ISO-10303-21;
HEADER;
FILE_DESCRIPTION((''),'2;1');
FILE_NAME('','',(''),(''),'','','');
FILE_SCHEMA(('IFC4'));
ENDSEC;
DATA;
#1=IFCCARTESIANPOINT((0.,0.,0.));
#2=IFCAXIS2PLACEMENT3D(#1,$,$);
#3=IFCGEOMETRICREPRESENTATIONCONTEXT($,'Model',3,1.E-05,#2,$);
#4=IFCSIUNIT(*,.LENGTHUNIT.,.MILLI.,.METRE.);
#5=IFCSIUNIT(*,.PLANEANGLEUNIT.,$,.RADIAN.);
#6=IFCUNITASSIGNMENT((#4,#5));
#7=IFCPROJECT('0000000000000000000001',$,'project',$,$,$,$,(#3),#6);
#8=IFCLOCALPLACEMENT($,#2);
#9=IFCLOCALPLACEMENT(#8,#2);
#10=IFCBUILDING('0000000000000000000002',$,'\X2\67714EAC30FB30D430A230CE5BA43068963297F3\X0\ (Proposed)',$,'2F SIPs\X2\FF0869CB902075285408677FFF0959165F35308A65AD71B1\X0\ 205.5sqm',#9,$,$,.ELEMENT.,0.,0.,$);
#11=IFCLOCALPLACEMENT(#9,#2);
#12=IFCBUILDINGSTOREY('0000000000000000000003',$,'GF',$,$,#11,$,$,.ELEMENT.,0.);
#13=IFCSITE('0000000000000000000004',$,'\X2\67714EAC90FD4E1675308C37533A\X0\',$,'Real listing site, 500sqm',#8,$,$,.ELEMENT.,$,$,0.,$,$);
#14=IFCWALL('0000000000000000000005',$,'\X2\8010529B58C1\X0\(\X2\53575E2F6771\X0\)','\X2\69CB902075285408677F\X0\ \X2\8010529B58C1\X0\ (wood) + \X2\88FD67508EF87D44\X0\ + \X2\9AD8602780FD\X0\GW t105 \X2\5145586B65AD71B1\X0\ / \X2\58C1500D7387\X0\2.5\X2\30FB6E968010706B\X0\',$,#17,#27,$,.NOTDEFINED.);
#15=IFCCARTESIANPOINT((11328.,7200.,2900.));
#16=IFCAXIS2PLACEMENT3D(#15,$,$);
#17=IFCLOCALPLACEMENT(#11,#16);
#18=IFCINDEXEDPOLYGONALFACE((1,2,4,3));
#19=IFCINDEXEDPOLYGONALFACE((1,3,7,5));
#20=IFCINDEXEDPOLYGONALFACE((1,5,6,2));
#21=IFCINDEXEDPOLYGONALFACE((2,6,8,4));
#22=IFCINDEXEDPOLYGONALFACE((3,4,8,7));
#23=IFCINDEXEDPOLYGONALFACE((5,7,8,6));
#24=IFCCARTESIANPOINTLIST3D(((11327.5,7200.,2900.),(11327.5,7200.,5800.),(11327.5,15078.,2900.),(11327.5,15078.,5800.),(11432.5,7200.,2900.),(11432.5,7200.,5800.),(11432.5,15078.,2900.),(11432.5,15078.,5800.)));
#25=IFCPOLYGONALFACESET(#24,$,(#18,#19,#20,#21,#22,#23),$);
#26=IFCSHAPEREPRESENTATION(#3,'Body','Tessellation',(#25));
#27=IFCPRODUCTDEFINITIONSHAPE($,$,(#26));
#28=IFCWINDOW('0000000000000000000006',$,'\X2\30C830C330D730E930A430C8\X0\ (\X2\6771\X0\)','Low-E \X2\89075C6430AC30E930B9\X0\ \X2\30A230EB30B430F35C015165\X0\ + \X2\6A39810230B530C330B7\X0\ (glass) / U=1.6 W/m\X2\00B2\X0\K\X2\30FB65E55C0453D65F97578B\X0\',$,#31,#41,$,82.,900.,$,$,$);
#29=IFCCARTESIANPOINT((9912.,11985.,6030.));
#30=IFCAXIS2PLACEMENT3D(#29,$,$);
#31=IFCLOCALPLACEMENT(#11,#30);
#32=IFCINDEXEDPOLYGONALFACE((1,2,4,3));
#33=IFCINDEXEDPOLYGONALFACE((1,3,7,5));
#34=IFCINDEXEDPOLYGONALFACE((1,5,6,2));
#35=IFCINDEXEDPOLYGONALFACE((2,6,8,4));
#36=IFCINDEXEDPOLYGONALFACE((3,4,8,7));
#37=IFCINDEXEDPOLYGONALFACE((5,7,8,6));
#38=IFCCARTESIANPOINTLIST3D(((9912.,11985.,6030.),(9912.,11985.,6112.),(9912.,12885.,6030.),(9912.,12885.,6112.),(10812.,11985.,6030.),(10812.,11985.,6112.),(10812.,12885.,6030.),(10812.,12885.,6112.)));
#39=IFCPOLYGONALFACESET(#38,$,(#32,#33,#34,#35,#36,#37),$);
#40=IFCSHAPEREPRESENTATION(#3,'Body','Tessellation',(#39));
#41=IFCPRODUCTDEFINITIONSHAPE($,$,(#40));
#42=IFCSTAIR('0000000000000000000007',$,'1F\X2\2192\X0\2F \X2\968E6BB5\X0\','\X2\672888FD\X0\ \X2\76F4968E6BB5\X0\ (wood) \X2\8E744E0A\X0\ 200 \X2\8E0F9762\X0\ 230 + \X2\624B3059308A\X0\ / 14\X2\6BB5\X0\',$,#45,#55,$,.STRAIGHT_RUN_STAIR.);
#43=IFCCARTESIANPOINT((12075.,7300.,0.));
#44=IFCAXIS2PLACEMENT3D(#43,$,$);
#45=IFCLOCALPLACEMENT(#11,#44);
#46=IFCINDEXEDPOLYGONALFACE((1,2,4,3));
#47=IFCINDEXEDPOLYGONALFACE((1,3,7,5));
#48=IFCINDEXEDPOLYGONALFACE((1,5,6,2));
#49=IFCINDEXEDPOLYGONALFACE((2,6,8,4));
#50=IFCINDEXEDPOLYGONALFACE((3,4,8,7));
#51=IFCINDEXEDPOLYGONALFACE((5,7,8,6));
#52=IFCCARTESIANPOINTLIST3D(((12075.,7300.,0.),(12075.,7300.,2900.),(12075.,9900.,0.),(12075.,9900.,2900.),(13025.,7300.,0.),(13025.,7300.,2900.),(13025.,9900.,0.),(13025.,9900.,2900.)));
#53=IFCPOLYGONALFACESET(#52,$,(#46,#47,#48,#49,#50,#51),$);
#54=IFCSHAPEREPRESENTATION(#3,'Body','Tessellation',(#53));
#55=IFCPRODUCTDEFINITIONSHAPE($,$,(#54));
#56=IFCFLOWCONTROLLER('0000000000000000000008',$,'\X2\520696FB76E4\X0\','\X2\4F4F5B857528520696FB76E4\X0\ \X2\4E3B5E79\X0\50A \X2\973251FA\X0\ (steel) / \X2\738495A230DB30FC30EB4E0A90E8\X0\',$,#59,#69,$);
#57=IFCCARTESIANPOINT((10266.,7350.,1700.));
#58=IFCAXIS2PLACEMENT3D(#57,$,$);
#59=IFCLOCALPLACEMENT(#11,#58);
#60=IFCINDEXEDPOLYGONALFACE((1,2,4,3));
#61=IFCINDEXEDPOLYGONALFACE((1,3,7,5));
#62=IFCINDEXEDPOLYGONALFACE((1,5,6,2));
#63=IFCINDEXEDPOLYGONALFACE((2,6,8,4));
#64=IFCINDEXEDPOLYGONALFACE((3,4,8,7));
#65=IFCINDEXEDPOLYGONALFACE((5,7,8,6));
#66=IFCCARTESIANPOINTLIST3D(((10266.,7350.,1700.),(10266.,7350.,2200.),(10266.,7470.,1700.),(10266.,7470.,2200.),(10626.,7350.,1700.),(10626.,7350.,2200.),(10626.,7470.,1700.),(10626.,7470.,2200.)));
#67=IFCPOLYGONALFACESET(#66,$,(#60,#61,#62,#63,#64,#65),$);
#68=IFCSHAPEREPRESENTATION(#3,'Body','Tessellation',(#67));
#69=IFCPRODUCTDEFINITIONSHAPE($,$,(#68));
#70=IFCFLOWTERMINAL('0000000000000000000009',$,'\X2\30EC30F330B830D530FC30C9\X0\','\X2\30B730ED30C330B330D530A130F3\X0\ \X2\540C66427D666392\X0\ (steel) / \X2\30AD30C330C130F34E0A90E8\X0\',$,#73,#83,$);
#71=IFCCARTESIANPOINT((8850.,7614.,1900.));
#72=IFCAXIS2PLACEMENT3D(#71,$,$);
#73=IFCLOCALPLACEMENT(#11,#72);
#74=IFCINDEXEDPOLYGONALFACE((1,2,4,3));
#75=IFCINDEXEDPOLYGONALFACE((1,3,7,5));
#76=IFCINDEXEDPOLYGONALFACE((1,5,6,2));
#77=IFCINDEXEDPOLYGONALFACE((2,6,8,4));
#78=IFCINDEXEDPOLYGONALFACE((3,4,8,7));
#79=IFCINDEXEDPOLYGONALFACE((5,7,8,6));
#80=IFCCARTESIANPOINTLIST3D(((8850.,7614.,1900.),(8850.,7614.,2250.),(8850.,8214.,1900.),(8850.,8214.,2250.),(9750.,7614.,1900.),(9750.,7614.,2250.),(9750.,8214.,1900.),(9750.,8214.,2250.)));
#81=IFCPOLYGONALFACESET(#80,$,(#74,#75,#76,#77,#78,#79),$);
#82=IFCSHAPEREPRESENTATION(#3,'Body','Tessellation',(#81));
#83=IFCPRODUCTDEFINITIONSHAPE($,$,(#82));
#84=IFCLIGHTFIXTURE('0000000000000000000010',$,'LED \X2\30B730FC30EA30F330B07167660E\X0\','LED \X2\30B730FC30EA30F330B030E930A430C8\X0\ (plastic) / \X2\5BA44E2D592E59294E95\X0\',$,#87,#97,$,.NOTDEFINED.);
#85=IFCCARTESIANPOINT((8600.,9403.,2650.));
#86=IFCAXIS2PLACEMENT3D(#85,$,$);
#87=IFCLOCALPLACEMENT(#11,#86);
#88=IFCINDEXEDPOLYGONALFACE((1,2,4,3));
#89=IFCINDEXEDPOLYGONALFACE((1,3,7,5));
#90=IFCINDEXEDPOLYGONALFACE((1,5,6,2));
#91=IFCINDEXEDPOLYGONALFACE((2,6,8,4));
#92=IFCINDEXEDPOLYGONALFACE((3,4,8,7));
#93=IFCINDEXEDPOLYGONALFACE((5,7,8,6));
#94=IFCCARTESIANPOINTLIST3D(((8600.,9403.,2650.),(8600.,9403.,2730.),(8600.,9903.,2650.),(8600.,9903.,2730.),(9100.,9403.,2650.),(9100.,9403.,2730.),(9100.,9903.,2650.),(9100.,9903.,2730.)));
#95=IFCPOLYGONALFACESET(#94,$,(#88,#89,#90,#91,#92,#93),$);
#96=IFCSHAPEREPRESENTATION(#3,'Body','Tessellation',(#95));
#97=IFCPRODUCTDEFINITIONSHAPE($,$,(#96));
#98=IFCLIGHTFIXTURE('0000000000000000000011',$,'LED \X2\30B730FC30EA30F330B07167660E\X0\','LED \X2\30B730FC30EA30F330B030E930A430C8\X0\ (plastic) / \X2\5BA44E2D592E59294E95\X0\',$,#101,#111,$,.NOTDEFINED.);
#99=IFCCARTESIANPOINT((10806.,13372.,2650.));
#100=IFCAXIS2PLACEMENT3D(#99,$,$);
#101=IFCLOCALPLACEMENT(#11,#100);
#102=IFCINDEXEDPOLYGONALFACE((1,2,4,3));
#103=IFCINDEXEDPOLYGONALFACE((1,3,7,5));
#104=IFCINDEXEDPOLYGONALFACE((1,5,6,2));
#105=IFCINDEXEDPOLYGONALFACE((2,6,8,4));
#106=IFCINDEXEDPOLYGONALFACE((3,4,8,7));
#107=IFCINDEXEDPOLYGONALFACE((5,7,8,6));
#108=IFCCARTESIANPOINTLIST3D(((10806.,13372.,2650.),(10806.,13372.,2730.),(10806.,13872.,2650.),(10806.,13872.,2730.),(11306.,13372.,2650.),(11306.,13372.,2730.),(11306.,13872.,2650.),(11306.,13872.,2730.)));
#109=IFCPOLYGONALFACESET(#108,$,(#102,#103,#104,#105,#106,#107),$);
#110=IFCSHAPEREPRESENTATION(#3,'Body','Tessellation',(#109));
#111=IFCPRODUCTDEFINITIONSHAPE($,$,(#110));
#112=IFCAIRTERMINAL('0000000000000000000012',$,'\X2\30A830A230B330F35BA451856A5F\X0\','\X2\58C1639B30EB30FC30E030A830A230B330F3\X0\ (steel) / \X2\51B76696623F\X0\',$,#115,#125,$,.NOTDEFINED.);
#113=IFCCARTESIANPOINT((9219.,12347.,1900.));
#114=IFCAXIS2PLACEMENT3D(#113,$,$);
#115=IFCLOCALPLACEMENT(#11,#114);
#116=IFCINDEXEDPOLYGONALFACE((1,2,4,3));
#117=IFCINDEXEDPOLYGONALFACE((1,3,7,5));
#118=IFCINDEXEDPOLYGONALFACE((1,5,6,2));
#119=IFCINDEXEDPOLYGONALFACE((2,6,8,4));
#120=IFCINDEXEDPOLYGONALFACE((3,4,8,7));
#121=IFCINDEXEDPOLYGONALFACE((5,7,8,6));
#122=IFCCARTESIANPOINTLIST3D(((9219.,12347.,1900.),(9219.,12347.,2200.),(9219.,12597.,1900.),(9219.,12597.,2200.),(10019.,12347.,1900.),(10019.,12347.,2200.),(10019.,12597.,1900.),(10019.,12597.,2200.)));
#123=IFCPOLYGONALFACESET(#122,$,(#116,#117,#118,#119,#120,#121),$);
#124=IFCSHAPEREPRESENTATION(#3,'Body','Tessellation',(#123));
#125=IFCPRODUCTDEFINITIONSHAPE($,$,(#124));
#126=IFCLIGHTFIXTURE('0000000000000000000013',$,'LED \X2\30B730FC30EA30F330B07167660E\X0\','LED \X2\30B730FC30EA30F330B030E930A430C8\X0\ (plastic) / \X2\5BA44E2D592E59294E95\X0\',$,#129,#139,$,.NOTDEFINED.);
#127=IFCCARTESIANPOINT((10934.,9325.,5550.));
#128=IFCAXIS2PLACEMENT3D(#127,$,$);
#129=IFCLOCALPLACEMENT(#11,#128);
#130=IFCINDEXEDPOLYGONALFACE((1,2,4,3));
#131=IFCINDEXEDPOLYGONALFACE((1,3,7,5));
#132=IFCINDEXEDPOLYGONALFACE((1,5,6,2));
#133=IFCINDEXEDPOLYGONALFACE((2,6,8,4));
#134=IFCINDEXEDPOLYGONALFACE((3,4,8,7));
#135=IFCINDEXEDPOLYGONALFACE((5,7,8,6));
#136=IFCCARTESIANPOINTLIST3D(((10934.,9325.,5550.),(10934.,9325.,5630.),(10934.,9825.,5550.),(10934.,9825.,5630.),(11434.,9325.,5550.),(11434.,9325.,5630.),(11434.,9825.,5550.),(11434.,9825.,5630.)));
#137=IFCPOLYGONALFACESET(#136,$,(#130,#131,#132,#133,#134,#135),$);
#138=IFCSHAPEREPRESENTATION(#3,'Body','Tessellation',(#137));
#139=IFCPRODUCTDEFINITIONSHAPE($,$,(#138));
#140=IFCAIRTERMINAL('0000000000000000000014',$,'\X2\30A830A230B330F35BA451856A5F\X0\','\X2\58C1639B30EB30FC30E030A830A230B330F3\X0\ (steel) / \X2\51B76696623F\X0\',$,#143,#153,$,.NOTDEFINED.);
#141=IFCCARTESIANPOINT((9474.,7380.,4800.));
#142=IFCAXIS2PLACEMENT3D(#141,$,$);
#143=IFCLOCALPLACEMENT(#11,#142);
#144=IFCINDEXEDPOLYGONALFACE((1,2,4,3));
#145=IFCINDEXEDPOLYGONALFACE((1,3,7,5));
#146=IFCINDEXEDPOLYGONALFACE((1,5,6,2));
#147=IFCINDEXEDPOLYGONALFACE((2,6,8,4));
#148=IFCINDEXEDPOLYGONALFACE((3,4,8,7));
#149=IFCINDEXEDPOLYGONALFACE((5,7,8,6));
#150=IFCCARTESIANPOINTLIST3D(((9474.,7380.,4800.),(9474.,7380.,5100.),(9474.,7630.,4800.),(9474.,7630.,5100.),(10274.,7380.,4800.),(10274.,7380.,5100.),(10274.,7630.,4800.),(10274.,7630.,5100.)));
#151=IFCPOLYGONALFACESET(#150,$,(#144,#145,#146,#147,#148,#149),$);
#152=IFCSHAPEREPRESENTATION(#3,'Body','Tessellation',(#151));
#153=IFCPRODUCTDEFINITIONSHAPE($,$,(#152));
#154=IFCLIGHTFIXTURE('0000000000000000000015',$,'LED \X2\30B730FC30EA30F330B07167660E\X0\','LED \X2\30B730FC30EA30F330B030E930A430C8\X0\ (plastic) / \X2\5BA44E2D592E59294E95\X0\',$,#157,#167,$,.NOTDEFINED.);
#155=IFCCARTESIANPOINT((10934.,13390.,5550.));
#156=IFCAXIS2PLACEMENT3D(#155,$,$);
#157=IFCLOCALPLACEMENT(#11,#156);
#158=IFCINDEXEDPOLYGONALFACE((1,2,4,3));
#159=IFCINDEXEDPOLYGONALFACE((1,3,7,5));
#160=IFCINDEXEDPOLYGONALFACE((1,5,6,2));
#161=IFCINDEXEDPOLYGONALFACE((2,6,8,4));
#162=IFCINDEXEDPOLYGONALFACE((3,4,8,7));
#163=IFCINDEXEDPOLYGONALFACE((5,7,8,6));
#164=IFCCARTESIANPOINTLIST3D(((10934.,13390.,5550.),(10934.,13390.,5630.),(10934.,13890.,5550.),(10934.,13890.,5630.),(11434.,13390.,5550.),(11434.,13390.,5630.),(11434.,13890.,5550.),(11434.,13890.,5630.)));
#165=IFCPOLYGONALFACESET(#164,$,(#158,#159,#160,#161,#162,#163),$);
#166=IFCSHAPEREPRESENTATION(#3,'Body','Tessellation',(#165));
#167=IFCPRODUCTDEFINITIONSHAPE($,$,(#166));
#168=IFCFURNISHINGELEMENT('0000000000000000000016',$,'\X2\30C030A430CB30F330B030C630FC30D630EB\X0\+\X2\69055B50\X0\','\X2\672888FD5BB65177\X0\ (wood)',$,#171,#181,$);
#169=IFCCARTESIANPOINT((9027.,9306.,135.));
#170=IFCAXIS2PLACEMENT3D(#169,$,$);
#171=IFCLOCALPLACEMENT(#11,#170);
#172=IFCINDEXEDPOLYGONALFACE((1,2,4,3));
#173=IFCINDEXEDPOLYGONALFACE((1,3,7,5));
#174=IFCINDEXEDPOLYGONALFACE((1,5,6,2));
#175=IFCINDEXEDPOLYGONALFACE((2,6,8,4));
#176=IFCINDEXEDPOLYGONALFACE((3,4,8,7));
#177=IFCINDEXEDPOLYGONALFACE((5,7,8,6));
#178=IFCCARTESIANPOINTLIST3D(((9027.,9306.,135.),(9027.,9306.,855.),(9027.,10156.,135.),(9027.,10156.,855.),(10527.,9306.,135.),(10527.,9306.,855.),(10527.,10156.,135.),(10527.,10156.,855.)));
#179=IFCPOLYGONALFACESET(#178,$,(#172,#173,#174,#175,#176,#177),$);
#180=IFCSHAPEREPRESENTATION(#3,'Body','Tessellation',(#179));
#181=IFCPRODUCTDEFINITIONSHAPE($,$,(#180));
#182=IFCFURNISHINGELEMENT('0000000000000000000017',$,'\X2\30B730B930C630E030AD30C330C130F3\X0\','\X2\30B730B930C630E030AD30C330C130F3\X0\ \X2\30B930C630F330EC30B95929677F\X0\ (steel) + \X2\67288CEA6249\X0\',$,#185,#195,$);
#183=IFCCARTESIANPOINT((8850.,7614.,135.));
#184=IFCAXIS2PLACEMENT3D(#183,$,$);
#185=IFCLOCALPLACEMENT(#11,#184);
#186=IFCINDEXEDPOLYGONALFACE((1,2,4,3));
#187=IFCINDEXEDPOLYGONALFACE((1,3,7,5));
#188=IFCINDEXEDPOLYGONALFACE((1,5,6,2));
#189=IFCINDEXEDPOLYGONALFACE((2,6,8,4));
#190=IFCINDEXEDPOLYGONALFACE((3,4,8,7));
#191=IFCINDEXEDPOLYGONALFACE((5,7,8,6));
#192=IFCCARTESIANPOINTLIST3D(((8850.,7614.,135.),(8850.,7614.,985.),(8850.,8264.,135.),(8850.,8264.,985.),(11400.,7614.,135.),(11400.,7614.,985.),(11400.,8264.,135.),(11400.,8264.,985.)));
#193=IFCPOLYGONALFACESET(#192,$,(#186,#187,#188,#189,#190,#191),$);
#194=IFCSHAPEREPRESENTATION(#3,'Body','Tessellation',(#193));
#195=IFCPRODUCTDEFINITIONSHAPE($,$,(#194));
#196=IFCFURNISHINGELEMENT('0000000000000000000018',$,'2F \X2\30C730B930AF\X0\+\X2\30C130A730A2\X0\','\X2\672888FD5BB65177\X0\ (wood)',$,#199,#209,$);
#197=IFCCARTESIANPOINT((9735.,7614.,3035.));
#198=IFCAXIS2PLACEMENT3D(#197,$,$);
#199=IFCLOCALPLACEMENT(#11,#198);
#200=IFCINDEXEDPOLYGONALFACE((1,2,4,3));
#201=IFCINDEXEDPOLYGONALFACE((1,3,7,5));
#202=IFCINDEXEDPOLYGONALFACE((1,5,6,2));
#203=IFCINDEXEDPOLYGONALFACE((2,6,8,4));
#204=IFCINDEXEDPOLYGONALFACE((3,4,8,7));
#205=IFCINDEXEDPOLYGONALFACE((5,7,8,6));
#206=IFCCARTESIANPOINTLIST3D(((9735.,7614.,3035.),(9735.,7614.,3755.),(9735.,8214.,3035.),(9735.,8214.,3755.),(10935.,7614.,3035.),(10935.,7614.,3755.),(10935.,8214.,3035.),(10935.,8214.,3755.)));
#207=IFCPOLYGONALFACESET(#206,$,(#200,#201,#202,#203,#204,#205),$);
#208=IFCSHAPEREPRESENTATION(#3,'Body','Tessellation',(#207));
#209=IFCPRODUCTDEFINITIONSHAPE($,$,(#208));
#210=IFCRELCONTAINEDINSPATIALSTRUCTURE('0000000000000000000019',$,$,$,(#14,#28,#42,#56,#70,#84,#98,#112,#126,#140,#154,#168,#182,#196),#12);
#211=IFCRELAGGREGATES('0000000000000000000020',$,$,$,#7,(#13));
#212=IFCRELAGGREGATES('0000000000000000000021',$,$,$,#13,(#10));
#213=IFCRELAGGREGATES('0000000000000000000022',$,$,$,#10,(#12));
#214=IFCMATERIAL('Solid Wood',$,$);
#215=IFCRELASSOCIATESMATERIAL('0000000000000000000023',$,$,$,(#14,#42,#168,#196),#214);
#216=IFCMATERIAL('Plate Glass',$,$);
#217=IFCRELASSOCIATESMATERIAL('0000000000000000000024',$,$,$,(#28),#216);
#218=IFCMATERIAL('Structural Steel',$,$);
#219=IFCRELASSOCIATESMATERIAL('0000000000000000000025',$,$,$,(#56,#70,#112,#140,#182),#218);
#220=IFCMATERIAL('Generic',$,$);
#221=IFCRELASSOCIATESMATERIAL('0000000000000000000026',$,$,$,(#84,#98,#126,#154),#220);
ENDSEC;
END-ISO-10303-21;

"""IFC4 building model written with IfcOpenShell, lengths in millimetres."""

from ifc_helpers import new_model, si_unit, frame, frame_2d, origin, place, context, project, spatial, rectangle, extrude, material, element, save


model = new_model("IFC4")

# Units and contexts
model_context = context("Model", 3, precision=1e-05, world=origin())
ifc_project = project(units=[si_unit("LENGTHUNIT", "METRE", prefix="MILLI"), si_unit("PLANEANGLEUNIT", "RADIAN")], contexts=[model_context])

# Site, building, storey
site_placement = place(None, origin())
site = spatial("IfcSite", under=ifc_project, at=site_placement, Name="東京都世田谷区", ObjectType="Real listing site, 500sqm", CompositionType="ELEMENT", RefElevation=0.0)
building_placement = place(site_placement, origin())
building = spatial("IfcBuilding", under=site, at=building_placement, Name="東京・ピアノ室と防音 (Proposed)", ObjectType="2F SIPs（構造用合板）外張り断熱 205.5sqm", CompositionType="ELEMENT", ElevationOfRefHeight=0.0, ElevationOfTerrain=0.0)
storey_placement = place(building_placement, origin())
storey = spatial("IfcBuildingStorey", under=building, at=storey_placement, Name="GF", CompositionType="ELEMENT", Elevation=0.0)

# Shared definitions
ifc_material_1 = material(Name="Solid Wood")

# Wall
wall_1_placement = place(storey_placement, frame((11328.0, 7200.0, 2900.0)))
element("IfcWall", 1, at=wall_1_placement, inside=storey, material=ifc_material_1, Name="耐力壁(南帯東)", Description="構造用合板 耐力壁 (wood) + 製材軸組 + 高性能GW t105 充填断熱 / 壁倍率2.5・準耐火", PredefinedType="NOTDEFINED", context=model_context, shape_type="SweptSolid", body=[
    extrude(rectangle(XDim=105.0, YDim=7878.0, at=frame_2d((52.0, 3939.0))), frame((11328.0, 7200.0, 2900.0)), (0.0, 0.0, 1.0), 2900.0),
])

# Window
ifc_material_2 = material(Name="Plate Glass")
window_placement = place(storey_placement, frame((9912.0, 11985.0, 6030.0)))
element("IfcWindow", 2, at=window_placement, inside=storey, material=ifc_material_2, Name="トップライト (東)", Description="Low-E 複層ガラス アルゴン封入 + 樹脂サッシ (glass) / U=1.6 W/m²K・日射取得型", OverallHeight=82.0, OverallWidth=900.0, context=model_context, shape_type="SweptSolid", body=[
    extrude(rectangle(XDim=900.0, YDim=900.0, at=frame_2d((450.0, 450.0))), frame((9912.0, 11985.0, 6030.0)), (0.0, 0.0, 1.0), 82.0),
])

# Stair
stair_placement = place(storey_placement, frame((12075.0, 7300.0, 0.0)))
element("IfcStair", 3, at=stair_placement, inside=storey, material=ifc_material_1, Name="1F→2F 階段", Description="木製 直階段 (wood) 蹴上 200 踏面 230 + 手すり / 14段", PredefinedType="STRAIGHT_RUN_STAIR", context=model_context, shape_type="SweptSolid", body=[
    extrude(rectangle(XDim=950.0, YDim=2600.0, at=frame_2d((475.0, 1300.0))), frame((12075.0, 7300.0, 0.0)), (0.0, 0.0, 1.0), 2900.0),
])

# Flow controller
ifc_material_3 = material(Name="Structural Steel")
flow_controller_placement = place(storey_placement, frame((10266.0, 7350.0, 1700.0)))
element("IfcFlowController", 4, at=flow_controller_placement, inside=storey, material=ifc_material_3, Name="分電盤", Description="住宅用分電盤 主幹50A 露出 (steel) / 玄関ホール上部", context=model_context, shape_type="SweptSolid", body=[
    extrude(rectangle(XDim=360.0, YDim=120.0, at=frame_2d((180.0, 60.0))), frame((10266.0, 7350.0, 1700.0)), (0.0, 0.0, 1.0), 500.0),
])

# Flow terminal
flow_terminal_placement = place(storey_placement, frame((8850.0, 7614.0, 1900.0)))
element("IfcFlowTerminal", 5, at=flow_terminal_placement, inside=storey, material=ifc_material_3, Name="レンジフード", Description="シロッコファン 同時給排 (steel) / キッチン上部", context=model_context, shape_type="SweptSolid", body=[
    extrude(rectangle(XDim=900.0, YDim=600.0, at=frame_2d((450.0, 300.0))), frame((8850.0, 7614.0, 1900.0)), (0.0, 0.0, 1.0), 350.0),
])

# Light fixtures
ifc_material_4 = material(Name="Generic")
light_fixture_1_placement = place(storey_placement, frame((8600.0, 9403.0, 2650.0)))
element("IfcLightFixture", 6, at=light_fixture_1_placement, inside=storey, material=ifc_material_4, Name="LED シーリング照明", Description="LED シーリングライト (plastic) / 室中央天井", PredefinedType="NOTDEFINED", context=model_context, shape_type="SweptSolid", body=[
    extrude(rectangle(XDim=500.0, YDim=500.0, at=frame_2d((250.0, 250.0))), frame((8600.0, 9403.0, 2650.0)), (0.0, 0.0, 1.0), 80.0),
])
light_fixture_2_placement = place(storey_placement, frame((10806.0, 13372.0, 2650.0)))
element("IfcLightFixture", 7, at=light_fixture_2_placement, inside=storey, material=ifc_material_4, Name="LED シーリング照明", Description="LED シーリングライト (plastic) / 室中央天井", PredefinedType="NOTDEFINED", context=model_context, shape_type="SweptSolid", body=[
    extrude(rectangle(XDim=500.0, YDim=500.0, at=frame_2d((250.0, 250.0))), frame((10806.0, 13372.0, 2650.0)), (0.0, 0.0, 1.0), 80.0),
])

# Air terminal
air_terminal_1_placement = place(storey_placement, frame((9219.0, 12347.0, 1900.0)))
element("IfcAirTerminal", 8, at=air_terminal_1_placement, inside=storey, material=ifc_material_3, Name="エアコン室内機", Description="壁掛ルームエアコン (steel) / 冷暖房", PredefinedType="NOTDEFINED", context=model_context, shape_type="SweptSolid", body=[
    extrude(rectangle(XDim=800.0, YDim=250.0, at=frame_2d((400.0, 125.0))), frame((9219.0, 12347.0, 1900.0)), (0.0, 0.0, 1.0), 300.0),
])

# Light fixture
light_fixture_3_placement = place(storey_placement, frame((10934.0, 9325.0, 5550.0)))
element("IfcLightFixture", 9, at=light_fixture_3_placement, inside=storey, material=ifc_material_4, Name="LED シーリング照明", Description="LED シーリングライト (plastic) / 室中央天井", PredefinedType="NOTDEFINED", context=model_context, shape_type="SweptSolid", body=[
    extrude(rectangle(XDim=500.0, YDim=500.0, at=frame_2d((250.0, 250.0))), frame((10934.0, 9325.0, 5550.0)), (0.0, 0.0, 1.0), 80.0),
])

# Air terminal
air_terminal_2_placement = place(storey_placement, frame((9474.0, 7380.0, 4800.0)))
element("IfcAirTerminal", 10, at=air_terminal_2_placement, inside=storey, material=ifc_material_3, Name="エアコン室内機", Description="壁掛ルームエアコン (steel) / 冷暖房", PredefinedType="NOTDEFINED", context=model_context, shape_type="SweptSolid", body=[
    extrude(rectangle(XDim=800.0, YDim=250.0, at=frame_2d((400.0, 125.0))), frame((9474.0, 7380.0, 4800.0)), (0.0, 0.0, 1.0), 300.0),
])

# Light fixture
light_fixture_4_placement = place(storey_placement, frame((10934.0, 13390.0, 5550.0)))
element("IfcLightFixture", 11, at=light_fixture_4_placement, inside=storey, material=ifc_material_4, Name="LED シーリング照明", Description="LED シーリングライト (plastic) / 室中央天井", PredefinedType="NOTDEFINED", context=model_context, shape_type="SweptSolid", body=[
    extrude(rectangle(XDim=500.0, YDim=500.0, at=frame_2d((250.0, 250.0))), frame((10934.0, 13390.0, 5550.0)), (0.0, 0.0, 1.0), 80.0),
])

# Furnishing elements
furnishing_1_placement = place(storey_placement, frame((9027.0, 9306.0, 135.0)))
element("IfcFurnishingElement", 12, at=furnishing_1_placement, inside=storey, material=ifc_material_1, Name="ダイニングテーブル+椅子", Description="木製家具 (wood)", context=model_context, shape_type="SweptSolid", body=[
    extrude(rectangle(XDim=1500.0, YDim=850.0, at=frame_2d((750.0, 425.0))), frame((9027.0, 9306.0, 135.0)), (0.0, 0.0, 1.0), 720.0),
])
furnishing_2_placement = place(storey_placement, frame((8850.0, 7614.0, 135.0)))
element("IfcFurnishingElement", 13, at=furnishing_2_placement, inside=storey, material=ifc_material_3, Name="システムキッチン", Description="システムキッチン ステンレス天板 (steel) + 木質扉", context=model_context, shape_type="SweptSolid", body=[
    extrude(rectangle(XDim=2550.0, YDim=650.0, at=frame_2d((1275.0, 325.0))), frame((8850.0, 7614.0, 135.0)), (0.0, 0.0, 1.0), 850.0),
])
furnishing_3_placement = place(storey_placement, frame((9735.0, 7614.0, 3035.0)))
element("IfcFurnishingElement", 14, at=furnishing_3_placement, inside=storey, material=ifc_material_1, Name="2F デスク+チェア", Description="木製家具 (wood)", context=model_context, shape_type="SweptSolid", body=[
    extrude(rectangle(XDim=1200.0, YDim=600.0, at=frame_2d((600.0, 300.0))), frame((9735.0, 7614.0, 3035.0)), (0.0, 0.0, 1.0), 720.0),
])

save(model, "model.ifc")
